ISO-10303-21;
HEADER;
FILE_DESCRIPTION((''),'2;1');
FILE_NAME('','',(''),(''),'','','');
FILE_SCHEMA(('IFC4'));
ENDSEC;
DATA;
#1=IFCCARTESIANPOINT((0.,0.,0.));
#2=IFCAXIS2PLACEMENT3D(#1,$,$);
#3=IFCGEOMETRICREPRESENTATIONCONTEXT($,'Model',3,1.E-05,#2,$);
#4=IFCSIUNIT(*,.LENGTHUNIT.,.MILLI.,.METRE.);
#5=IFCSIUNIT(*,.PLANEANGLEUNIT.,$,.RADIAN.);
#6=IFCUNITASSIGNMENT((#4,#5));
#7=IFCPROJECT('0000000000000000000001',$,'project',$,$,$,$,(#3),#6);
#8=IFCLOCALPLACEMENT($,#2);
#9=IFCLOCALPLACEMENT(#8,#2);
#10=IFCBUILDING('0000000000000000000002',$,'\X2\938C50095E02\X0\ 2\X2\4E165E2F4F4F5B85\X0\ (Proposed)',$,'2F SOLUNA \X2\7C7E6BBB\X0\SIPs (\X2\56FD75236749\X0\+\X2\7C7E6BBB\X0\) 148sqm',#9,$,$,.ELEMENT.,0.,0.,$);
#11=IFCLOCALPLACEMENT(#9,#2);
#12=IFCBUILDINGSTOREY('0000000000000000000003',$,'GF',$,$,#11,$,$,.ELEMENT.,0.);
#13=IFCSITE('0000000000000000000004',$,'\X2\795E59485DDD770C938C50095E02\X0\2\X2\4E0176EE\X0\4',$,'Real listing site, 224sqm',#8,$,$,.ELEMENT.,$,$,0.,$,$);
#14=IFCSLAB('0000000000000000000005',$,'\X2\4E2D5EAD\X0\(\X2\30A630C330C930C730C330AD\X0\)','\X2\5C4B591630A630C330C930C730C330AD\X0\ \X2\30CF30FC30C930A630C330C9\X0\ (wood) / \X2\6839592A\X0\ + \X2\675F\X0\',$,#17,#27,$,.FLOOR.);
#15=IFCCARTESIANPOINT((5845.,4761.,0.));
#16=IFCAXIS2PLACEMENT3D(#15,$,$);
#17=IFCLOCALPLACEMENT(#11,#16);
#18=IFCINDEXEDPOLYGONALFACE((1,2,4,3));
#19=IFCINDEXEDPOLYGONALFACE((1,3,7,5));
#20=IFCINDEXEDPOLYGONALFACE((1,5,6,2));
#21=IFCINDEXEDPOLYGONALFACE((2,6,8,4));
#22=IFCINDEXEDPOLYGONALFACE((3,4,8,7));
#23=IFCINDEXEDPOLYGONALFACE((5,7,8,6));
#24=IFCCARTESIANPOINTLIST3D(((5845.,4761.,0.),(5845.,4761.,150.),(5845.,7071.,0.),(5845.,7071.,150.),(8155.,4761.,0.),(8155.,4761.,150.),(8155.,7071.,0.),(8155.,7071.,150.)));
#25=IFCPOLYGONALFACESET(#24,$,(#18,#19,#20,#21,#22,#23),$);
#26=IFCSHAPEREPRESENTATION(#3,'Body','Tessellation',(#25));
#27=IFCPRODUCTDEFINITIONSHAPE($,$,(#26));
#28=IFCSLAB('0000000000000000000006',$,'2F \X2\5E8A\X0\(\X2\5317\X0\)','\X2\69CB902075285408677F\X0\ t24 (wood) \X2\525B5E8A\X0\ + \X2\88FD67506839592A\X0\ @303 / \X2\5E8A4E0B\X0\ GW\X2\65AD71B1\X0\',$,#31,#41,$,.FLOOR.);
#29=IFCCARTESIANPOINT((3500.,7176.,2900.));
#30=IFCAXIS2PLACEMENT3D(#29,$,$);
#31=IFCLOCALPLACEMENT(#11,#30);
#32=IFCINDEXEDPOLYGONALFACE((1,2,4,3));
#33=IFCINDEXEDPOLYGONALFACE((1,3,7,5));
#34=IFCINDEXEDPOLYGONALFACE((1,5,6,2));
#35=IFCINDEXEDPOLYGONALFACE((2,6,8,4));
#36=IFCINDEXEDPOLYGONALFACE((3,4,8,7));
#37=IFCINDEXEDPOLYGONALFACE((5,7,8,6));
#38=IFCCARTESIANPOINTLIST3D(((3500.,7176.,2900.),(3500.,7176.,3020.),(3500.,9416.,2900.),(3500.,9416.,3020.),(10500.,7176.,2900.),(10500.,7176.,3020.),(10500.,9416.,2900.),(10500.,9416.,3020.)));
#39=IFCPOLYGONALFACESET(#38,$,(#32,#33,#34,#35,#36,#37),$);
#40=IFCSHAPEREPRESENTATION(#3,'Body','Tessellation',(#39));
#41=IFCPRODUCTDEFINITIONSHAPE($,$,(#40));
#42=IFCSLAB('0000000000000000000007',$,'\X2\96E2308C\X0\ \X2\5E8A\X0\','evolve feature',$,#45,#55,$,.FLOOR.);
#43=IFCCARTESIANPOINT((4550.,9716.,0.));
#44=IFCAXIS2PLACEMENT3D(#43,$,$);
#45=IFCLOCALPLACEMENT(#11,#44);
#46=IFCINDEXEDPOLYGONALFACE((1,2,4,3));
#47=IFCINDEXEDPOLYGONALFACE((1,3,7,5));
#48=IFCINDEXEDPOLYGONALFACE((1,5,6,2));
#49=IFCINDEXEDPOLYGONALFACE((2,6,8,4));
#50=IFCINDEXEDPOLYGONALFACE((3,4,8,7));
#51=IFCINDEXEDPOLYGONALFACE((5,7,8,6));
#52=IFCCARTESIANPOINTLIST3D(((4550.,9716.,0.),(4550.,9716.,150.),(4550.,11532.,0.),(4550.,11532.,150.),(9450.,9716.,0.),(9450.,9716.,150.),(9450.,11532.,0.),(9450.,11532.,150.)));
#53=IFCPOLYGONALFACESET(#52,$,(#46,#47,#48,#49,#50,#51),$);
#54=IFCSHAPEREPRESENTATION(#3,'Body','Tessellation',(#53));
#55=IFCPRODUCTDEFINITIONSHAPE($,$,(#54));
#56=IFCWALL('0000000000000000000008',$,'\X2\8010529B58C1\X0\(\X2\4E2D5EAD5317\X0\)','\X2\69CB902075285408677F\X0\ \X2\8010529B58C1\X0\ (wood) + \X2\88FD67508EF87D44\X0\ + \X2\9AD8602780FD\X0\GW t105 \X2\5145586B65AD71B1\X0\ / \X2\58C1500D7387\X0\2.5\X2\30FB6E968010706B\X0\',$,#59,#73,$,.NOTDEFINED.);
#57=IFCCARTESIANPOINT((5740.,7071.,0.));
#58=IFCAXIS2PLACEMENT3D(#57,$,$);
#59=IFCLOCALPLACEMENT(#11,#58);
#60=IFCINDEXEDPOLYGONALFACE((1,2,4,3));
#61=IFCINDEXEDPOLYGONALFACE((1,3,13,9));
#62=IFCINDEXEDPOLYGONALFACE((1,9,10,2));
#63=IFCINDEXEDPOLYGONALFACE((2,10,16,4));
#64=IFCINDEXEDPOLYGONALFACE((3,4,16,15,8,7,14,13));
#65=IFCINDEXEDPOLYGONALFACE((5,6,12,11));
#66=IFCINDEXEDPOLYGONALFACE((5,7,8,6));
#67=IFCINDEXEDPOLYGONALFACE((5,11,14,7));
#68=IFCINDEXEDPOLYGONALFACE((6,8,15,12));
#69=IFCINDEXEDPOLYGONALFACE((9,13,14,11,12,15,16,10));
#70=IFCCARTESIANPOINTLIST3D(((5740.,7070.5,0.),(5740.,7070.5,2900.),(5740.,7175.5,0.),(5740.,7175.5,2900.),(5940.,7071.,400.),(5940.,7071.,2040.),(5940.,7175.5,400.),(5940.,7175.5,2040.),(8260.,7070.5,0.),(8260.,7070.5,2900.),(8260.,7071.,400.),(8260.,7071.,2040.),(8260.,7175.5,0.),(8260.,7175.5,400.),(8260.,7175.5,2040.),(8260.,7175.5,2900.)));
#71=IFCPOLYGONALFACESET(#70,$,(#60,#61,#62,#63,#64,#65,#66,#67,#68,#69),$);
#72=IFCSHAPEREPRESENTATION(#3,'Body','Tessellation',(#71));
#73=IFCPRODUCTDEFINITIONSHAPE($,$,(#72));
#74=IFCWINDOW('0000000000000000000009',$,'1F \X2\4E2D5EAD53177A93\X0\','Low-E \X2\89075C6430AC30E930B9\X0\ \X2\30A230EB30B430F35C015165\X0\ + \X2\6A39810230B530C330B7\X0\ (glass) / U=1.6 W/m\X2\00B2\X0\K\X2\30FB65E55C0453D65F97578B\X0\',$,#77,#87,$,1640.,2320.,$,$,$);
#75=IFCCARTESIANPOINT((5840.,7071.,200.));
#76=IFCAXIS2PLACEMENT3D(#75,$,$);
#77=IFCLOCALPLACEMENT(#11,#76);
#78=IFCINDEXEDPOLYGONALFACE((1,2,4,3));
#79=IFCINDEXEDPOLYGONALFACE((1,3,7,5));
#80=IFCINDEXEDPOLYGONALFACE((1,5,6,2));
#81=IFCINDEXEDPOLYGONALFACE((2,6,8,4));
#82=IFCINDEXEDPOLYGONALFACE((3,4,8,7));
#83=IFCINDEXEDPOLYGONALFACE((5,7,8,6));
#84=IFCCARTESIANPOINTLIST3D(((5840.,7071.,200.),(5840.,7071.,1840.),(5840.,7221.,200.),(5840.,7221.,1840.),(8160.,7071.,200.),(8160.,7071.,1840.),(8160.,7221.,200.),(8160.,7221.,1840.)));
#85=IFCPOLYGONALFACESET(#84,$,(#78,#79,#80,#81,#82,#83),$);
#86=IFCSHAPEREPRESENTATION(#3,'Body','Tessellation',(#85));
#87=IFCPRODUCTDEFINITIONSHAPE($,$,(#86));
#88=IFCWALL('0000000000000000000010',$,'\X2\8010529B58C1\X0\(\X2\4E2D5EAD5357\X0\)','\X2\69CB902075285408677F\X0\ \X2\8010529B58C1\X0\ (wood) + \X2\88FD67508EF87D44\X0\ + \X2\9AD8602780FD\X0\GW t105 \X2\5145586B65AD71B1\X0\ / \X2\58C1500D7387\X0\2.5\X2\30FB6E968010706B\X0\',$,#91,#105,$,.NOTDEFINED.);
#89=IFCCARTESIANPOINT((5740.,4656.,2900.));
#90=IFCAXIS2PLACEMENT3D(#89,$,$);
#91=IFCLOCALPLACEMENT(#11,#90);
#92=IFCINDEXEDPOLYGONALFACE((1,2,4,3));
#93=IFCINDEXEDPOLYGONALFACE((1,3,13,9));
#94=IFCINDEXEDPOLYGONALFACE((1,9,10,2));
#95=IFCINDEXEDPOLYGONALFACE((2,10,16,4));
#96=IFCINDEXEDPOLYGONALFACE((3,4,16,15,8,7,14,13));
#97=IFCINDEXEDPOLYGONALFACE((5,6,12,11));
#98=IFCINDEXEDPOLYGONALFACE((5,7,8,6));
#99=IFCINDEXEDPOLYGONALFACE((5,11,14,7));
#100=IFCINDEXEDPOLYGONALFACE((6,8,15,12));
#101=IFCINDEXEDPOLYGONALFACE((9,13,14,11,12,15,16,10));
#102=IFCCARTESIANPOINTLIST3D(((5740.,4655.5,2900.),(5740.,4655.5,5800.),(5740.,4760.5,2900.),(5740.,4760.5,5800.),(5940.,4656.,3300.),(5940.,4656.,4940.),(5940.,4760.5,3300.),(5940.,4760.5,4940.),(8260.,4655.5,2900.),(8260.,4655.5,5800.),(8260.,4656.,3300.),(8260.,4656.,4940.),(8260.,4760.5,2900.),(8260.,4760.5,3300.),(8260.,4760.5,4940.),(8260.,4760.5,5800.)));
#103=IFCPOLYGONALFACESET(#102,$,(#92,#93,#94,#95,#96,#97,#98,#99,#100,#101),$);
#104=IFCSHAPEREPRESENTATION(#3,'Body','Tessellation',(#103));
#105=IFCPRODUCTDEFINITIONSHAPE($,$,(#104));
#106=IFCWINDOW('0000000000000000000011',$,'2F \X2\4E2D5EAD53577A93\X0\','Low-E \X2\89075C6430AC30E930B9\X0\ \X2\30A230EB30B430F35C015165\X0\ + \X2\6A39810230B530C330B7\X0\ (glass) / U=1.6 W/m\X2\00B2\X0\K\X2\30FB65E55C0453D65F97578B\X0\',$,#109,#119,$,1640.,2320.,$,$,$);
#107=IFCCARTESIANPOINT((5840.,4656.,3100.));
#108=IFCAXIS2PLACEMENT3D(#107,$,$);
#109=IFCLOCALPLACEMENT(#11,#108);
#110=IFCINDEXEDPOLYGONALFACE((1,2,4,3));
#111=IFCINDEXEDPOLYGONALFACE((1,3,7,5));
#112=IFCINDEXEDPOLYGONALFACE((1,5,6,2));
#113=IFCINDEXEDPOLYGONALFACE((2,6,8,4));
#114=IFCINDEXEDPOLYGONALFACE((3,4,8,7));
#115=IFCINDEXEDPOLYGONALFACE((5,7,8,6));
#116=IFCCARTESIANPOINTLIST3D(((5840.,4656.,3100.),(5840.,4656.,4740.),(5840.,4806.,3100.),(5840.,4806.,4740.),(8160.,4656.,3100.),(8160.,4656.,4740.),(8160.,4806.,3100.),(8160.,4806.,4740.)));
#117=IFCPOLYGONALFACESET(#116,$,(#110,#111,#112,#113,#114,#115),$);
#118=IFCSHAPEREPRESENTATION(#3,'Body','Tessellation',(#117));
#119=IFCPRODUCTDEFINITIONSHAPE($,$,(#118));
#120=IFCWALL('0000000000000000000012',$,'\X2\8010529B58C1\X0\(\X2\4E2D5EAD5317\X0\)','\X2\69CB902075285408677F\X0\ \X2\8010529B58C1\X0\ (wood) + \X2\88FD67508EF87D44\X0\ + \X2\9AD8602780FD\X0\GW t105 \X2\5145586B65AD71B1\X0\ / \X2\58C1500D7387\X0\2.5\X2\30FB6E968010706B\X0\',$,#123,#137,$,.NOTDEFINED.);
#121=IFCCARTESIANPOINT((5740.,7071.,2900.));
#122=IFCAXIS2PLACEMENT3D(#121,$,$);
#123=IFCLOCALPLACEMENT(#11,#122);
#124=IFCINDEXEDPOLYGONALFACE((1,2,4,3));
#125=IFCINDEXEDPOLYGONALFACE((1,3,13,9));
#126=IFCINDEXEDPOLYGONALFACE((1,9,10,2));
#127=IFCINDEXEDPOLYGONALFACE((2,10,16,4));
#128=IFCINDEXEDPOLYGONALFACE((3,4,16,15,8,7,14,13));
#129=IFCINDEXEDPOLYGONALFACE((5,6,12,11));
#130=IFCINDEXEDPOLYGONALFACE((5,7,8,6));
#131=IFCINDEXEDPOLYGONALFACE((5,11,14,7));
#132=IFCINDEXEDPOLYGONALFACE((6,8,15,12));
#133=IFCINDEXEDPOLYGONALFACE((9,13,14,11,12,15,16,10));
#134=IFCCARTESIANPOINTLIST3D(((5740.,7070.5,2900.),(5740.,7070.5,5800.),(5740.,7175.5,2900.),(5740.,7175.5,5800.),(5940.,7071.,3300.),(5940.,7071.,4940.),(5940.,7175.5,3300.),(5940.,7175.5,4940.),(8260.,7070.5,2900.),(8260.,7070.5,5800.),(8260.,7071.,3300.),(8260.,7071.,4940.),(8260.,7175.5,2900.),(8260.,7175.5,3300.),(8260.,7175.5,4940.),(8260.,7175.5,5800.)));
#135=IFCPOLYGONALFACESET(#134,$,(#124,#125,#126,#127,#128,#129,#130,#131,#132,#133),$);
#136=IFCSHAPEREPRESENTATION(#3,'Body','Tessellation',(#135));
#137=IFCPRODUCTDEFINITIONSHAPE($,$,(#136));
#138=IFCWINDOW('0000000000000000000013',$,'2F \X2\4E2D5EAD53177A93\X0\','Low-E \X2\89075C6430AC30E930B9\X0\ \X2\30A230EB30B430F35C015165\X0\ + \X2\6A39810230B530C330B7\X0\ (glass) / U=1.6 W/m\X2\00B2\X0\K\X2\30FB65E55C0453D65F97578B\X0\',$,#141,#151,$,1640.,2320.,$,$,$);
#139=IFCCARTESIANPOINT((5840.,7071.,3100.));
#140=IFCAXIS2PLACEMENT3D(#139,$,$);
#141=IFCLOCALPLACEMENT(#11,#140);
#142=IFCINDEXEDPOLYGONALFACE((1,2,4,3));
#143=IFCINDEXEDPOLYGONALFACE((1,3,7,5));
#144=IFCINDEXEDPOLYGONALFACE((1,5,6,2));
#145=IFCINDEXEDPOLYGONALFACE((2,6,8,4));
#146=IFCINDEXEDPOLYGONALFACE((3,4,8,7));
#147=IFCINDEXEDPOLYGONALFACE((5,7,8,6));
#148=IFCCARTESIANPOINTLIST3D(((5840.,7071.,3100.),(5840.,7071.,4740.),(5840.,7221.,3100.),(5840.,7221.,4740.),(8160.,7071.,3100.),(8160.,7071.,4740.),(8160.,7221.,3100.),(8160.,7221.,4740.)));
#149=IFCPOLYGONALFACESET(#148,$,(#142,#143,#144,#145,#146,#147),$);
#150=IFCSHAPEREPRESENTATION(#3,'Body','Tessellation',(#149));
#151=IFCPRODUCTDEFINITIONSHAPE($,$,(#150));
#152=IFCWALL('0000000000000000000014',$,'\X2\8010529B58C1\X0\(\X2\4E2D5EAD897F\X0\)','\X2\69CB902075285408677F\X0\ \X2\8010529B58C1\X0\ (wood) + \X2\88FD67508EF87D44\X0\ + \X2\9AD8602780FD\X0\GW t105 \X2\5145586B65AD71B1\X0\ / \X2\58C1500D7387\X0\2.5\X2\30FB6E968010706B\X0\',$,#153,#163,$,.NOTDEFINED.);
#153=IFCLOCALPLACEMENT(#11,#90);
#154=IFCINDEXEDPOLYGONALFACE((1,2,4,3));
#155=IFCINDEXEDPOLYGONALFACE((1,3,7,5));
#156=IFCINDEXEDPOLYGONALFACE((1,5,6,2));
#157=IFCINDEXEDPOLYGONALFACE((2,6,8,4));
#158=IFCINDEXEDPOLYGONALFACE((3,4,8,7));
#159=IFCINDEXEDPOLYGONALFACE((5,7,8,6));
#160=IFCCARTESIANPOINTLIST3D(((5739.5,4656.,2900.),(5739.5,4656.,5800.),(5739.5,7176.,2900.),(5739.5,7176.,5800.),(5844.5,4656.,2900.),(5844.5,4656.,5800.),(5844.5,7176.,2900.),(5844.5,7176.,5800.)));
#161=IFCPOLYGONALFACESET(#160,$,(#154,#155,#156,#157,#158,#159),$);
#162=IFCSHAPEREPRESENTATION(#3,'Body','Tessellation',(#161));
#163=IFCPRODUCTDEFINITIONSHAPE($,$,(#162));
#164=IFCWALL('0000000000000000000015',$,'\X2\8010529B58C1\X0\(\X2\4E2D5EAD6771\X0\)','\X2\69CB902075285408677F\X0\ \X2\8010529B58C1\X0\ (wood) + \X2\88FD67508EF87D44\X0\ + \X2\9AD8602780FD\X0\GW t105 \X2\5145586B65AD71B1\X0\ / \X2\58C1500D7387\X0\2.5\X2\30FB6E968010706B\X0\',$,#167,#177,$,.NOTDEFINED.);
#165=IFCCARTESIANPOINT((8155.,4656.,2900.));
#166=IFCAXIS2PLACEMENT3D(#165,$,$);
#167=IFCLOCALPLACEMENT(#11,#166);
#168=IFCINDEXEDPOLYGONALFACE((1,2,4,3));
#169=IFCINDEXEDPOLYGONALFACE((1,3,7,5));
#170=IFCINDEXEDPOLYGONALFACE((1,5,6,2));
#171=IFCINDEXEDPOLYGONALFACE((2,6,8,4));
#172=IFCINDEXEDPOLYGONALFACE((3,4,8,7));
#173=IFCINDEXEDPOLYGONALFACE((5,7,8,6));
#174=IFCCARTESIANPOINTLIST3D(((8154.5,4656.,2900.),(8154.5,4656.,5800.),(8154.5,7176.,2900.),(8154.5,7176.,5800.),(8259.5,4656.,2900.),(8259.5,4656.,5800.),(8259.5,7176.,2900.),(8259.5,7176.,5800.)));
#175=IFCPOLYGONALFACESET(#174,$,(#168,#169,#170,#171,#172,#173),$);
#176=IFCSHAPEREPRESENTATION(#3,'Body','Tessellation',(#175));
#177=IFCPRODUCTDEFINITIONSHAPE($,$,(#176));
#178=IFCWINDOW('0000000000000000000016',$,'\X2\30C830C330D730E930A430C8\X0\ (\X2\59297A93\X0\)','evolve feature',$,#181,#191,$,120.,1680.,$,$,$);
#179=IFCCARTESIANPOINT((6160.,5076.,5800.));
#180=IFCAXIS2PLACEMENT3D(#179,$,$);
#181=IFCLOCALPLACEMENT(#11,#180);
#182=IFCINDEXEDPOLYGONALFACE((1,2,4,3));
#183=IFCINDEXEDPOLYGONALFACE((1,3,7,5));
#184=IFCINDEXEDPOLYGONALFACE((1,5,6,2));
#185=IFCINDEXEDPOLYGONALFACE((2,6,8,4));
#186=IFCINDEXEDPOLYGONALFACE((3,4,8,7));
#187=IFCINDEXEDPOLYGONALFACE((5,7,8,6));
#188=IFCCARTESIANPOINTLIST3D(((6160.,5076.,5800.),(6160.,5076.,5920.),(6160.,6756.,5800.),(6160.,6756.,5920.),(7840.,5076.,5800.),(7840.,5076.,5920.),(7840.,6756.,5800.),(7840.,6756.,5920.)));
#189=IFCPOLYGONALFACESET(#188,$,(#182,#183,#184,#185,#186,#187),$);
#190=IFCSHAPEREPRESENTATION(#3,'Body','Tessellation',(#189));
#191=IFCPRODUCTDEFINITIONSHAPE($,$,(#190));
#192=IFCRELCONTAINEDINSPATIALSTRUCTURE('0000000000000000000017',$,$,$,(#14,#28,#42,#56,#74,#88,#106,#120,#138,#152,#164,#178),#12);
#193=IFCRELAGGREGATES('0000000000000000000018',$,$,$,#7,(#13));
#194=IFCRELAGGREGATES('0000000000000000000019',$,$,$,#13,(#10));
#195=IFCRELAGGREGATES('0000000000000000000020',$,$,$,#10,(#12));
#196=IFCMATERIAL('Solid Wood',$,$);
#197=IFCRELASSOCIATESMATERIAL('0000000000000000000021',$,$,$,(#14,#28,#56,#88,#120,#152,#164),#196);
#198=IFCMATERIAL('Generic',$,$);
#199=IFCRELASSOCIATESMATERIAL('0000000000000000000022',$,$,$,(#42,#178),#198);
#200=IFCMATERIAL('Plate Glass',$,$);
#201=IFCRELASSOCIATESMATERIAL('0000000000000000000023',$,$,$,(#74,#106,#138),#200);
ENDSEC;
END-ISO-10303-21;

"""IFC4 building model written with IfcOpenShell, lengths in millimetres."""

from ifc_helpers import new_model, si_unit, frame, frame_2d, origin, place, context, project, spatial, rectangle, extrude, material, element, fill, save


model = new_model("IFC4")

# Units and contexts
model_context = context("Model", 3, precision=1e-05, world=origin())
ifc_project = project(units=[si_unit("LENGTHUNIT", "METRE", prefix="MILLI"), si_unit("PLANEANGLEUNIT", "RADIAN")], contexts=[model_context])

# Site, building, storey
site_placement = place(None, origin())
site = spatial("IfcSite", under=ifc_project, at=site_placement, Name="神奈川県鎌倉市2丁目4", ObjectType="Real listing site, 224sqm", CompositionType="ELEMENT", RefElevation=0.0)
building_placement = place(site_placement, origin())
building = spatial("IfcBuilding", under=site, at=building_placement, Name="鎌倉市 2世帯住宅 (Proposed)", ObjectType="2F SOLUNA 籾殻SIPs (国産杉+籾殻) 148sqm", CompositionType="ELEMENT", ElevationOfRefHeight=0.0, ElevationOfTerrain=0.0)
storey_placement = place(building_placement, origin())
storey = spatial("IfcBuildingStorey", under=building, at=storey_placement, Name="GF", CompositionType="ELEMENT", Elevation=0.0)

# Slabs
ifc_material_1 = material(Name="Solid Wood")
slab_1_placement = place(storey_placement, frame((5845.0, 4761.0, 0.0)))
element("IfcSlab", 1, at=slab_1_placement, inside=storey, material=ifc_material_1, Name="中庭(ウッドデッキ)", Description="屋外ウッドデッキ ハードウッド (wood) / 根太 + 束", PredefinedType="FLOOR", context=model_context, shape_type="SweptSolid", body=[
    extrude(rectangle(XDim=2310.0, YDim=2310.0, at=frame_2d((1155.0, 1155.0))), frame((5845.0, 4761.0, 0.0)), (0.0, 0.0, 1.0), 150.0),
])
slab_2_placement = place(storey_placement, frame((3500.0, 7176.0, 2900.0)))
element("IfcSlab", 2, at=slab_2_placement, inside=storey, material=ifc_material_1, Name="2F 床(北)", Description="構造用合板 t24 (wood) 剛床 + 製材根太 @303 / 床下 GW断熱", PredefinedType="FLOOR", context=model_context, shape_type="SweptSolid", body=[
    extrude(rectangle(XDim=7000.0, YDim=2240.0, at=frame_2d((3500.0, 1120.0))), frame((3500.0, 7176.0, 2900.0)), (0.0, 0.0, 1.0), 120.0),
])
ifc_material_2 = material(Name="Generic")
slab_3_placement = place(storey_placement, frame((4550.0, 9716.0, 0.0)))
element("IfcSlab", 3, at=slab_3_placement, inside=storey, material=ifc_material_2, Name="離れ 床", Description="evolve feature", PredefinedType="FLOOR", context=model_context, shape_type="SweptSolid", body=[
    extrude(rectangle(XDim=4900.0, YDim=1816.0, at=frame_2d((2450.0, 908.0))), frame((4550.0, 9716.0, 0.0)), (0.0, 0.0, 1.0), 150.0),
])

# Wall, opening, window
wall_1_placement = place(storey_placement, frame((5740.0, 7071.0, 0.0)))
wall_1 = element("IfcWall", 4, at=wall_1_placement, inside=storey, material=ifc_material_1, Name="耐力壁(中庭北)", Description="構造用合板 耐力壁 (wood) + 製材軸組 + 高性能GW t105 充填断熱 / 壁倍率2.5・準耐火", PredefinedType="NOTDEFINED", context=model_context, shape_type="SweptSolid", body=[
    extrude(rectangle(XDim=2520.0, YDim=105.0, at=frame_2d((1260.0, 52.0))), frame((5740.0, 7071.0, 0.0)), (0.0, 0.0, 1.0), 2900.0),
])
opening_1_placement = place(storey_placement, frame((5840.0, 7071.0, 200.0)))
opening_1 = element("IfcOpeningElement", 5, at=opening_1_placement, cuts=wall_1, PredefinedType="NOTDEFINED", context=model_context, shape_type="SweptSolid", body=[
    extrude(rectangle(XDim=2320.0, YDim=150.0, at=frame_2d((1160.0, 75.0))), frame((5840.0, 7071.0, 200.0)), (0.0, 0.0, 1.0), 1640.0),
])
ifc_material_3 = material(Name="Plate Glass")
window_1_placement = place(storey_placement, frame((5840.0, 7071.0, 200.0)))
window_1 = element("IfcWindow", 6, at=window_1_placement, inside=storey, material=ifc_material_3, Name="1F 中庭北窓", Description="Low-E 複層ガラス アルゴン封入 + 樹脂サッシ (glass) / U=1.6 W/m²K・日射取得型", OverallHeight=1640.0, OverallWidth=2320.0, context=model_context, shape_type="SweptSolid", body=[
    extrude(rectangle(XDim=2320.0, YDim=150.0, at=frame_2d((1160.0, 75.0))), frame((5840.0, 7071.0, 200.0)), (0.0, 0.0, 1.0), 1640.0),
])
fill(opening_1, window_1)

# Walls, openings, windows
wall_2_placement = place(storey_placement, frame((5740.0, 4656.0, 2900.0)))
wall_2 = element("IfcWall", 7, at=wall_2_placement, inside=storey, material=ifc_material_1, Name="耐力壁(中庭南)", Description="構造用合板 耐力壁 (wood) + 製材軸組 + 高性能GW t105 充填断熱 / 壁倍率2.5・準耐火", PredefinedType="NOTDEFINED", context=model_context, shape_type="SweptSolid", body=[
    extrude(rectangle(XDim=2520.0, YDim=105.0, at=frame_2d((1260.0, 52.0))), frame((5740.0, 4656.0, 2900.0)), (0.0, 0.0, 1.0), 2900.0),
])
opening_2_placement = place(storey_placement, frame((5840.0, 4656.0, 3100.0)))
opening_2 = element("IfcOpeningElement", 8, at=opening_2_placement, cuts=wall_2, PredefinedType="NOTDEFINED", context=model_context, shape_type="SweptSolid", body=[
    extrude(rectangle(XDim=2320.0, YDim=150.0, at=frame_2d((1160.0, 75.0))), frame((5840.0, 4656.0, 3100.0)), (0.0, 0.0, 1.0), 1640.0),
])
window_2_placement = place(storey_placement, frame((5840.0, 4656.0, 3100.0)))
window_2 = element("IfcWindow", 9, at=window_2_placement, inside=storey, material=ifc_material_3, Name="2F 中庭南窓", Description="Low-E 複層ガラス アルゴン封入 + 樹脂サッシ (glass) / U=1.6 W/m²K・日射取得型", OverallHeight=1640.0, OverallWidth=2320.0, context=model_context, shape_type="SweptSolid", body=[
    extrude(rectangle(XDim=2320.0, YDim=150.0, at=frame_2d((1160.0, 75.0))), frame((5840.0, 4656.0, 3100.0)), (0.0, 0.0, 1.0), 1640.0),
])
fill(opening_2, window_2)
wall_3_placement = place(storey_placement, frame((5740.0, 7071.0, 2900.0)))
wall_3 = element("IfcWall", 10, at=wall_3_placement, inside=storey, material=ifc_material_1, Name="耐力壁(中庭北)", Description="構造用合板 耐力壁 (wood) + 製材軸組 + 高性能GW t105 充填断熱 / 壁倍率2.5・準耐火", PredefinedType="NOTDEFINED", context=model_context, shape_type="SweptSolid", body=[
    extrude(rectangle(XDim=2520.0, YDim=105.0, at=frame_2d((1260.0, 52.0))), frame((5740.0, 7071.0, 2900.0)), (0.0, 0.0, 1.0), 2900.0),
])
opening_3_placement = place(storey_placement, frame((5840.0, 7071.0, 3100.0)))
opening_3 = element("IfcOpeningElement", 11, at=opening_3_placement, cuts=wall_3, PredefinedType="NOTDEFINED", context=model_context, shape_type="SweptSolid", body=[
    extrude(rectangle(XDim=2320.0, YDim=150.0, at=frame_2d((1160.0, 75.0))), frame((5840.0, 7071.0, 3100.0)), (0.0, 0.0, 1.0), 1640.0),
])
window_3_placement = place(storey_placement, frame((5840.0, 7071.0, 3100.0)))
window_3 = element("IfcWindow", 12, at=window_3_placement, inside=storey, material=ifc_material_3, Name="2F 中庭北窓", Description="Low-E 複層ガラス アルゴン封入 + 樹脂サッシ (glass) / U=1.6 W/m²K・日射取得型", OverallHeight=1640.0, OverallWidth=2320.0, context=model_context, shape_type="SweptSolid", body=[
    extrude(rectangle(XDim=2320.0, YDim=150.0, at=frame_2d((1160.0, 75.0))), frame((5840.0, 7071.0, 3100.0)), (0.0, 0.0, 1.0), 1640.0),
])
fill(opening_3, window_3)

# Walls
wall_4_placement = place(storey_placement, frame((5740.0, 4656.0, 2900.0)))
element("IfcWall", 13, at=wall_4_placement, inside=storey, material=ifc_material_1, Name="耐力壁(中庭西)", Description="構造用合板 耐力壁 (wood) + 製材軸組 + 高性能GW t105 充填断熱 / 壁倍率2.5・準耐火", PredefinedType="NOTDEFINED", context=model_context, shape_type="SweptSolid", body=[
    extrude(rectangle(XDim=105.0, YDim=2520.0, at=frame_2d((52.0, 1260.0))), frame((5740.0, 4656.0, 2900.0)), (0.0, 0.0, 1.0), 2900.0),
])
wall_5_placement = place(storey_placement, frame((8155.0, 4656.0, 2900.0)))
element("IfcWall", 14, at=wall_5_placement, inside=storey, material=ifc_material_1, Name="耐力壁(中庭東)", Description="構造用合板 耐力壁 (wood) + 製材軸組 + 高性能GW t105 充填断熱 / 壁倍率2.5・準耐火", PredefinedType="NOTDEFINED", context=model_context, shape_type="SweptSolid", body=[
    extrude(rectangle(XDim=105.0, YDim=2520.0, at=frame_2d((52.0, 1260.0))), frame((8155.0, 4656.0, 2900.0)), (0.0, 0.0, 1.0), 2900.0),
])

# Window
window_4_placement = place(storey_placement, frame((6160.0, 5076.0, 5800.0)))
element("IfcWindow", 15, at=window_4_placement, inside=storey, material=ifc_material_2, Name="トップライト (天窓)", Description="evolve feature", OverallHeight=120.0, OverallWidth=1680.0, context=model_context, shape_type="SweptSolid", body=[
    extrude(rectangle(XDim=1680.0, YDim=1680.0, at=frame_2d((840.0, 840.0))), frame((6160.0, 5076.0, 5800.0)), (0.0, 0.0, 1.0), 120.0),
])

save(model, "model.ifc")
